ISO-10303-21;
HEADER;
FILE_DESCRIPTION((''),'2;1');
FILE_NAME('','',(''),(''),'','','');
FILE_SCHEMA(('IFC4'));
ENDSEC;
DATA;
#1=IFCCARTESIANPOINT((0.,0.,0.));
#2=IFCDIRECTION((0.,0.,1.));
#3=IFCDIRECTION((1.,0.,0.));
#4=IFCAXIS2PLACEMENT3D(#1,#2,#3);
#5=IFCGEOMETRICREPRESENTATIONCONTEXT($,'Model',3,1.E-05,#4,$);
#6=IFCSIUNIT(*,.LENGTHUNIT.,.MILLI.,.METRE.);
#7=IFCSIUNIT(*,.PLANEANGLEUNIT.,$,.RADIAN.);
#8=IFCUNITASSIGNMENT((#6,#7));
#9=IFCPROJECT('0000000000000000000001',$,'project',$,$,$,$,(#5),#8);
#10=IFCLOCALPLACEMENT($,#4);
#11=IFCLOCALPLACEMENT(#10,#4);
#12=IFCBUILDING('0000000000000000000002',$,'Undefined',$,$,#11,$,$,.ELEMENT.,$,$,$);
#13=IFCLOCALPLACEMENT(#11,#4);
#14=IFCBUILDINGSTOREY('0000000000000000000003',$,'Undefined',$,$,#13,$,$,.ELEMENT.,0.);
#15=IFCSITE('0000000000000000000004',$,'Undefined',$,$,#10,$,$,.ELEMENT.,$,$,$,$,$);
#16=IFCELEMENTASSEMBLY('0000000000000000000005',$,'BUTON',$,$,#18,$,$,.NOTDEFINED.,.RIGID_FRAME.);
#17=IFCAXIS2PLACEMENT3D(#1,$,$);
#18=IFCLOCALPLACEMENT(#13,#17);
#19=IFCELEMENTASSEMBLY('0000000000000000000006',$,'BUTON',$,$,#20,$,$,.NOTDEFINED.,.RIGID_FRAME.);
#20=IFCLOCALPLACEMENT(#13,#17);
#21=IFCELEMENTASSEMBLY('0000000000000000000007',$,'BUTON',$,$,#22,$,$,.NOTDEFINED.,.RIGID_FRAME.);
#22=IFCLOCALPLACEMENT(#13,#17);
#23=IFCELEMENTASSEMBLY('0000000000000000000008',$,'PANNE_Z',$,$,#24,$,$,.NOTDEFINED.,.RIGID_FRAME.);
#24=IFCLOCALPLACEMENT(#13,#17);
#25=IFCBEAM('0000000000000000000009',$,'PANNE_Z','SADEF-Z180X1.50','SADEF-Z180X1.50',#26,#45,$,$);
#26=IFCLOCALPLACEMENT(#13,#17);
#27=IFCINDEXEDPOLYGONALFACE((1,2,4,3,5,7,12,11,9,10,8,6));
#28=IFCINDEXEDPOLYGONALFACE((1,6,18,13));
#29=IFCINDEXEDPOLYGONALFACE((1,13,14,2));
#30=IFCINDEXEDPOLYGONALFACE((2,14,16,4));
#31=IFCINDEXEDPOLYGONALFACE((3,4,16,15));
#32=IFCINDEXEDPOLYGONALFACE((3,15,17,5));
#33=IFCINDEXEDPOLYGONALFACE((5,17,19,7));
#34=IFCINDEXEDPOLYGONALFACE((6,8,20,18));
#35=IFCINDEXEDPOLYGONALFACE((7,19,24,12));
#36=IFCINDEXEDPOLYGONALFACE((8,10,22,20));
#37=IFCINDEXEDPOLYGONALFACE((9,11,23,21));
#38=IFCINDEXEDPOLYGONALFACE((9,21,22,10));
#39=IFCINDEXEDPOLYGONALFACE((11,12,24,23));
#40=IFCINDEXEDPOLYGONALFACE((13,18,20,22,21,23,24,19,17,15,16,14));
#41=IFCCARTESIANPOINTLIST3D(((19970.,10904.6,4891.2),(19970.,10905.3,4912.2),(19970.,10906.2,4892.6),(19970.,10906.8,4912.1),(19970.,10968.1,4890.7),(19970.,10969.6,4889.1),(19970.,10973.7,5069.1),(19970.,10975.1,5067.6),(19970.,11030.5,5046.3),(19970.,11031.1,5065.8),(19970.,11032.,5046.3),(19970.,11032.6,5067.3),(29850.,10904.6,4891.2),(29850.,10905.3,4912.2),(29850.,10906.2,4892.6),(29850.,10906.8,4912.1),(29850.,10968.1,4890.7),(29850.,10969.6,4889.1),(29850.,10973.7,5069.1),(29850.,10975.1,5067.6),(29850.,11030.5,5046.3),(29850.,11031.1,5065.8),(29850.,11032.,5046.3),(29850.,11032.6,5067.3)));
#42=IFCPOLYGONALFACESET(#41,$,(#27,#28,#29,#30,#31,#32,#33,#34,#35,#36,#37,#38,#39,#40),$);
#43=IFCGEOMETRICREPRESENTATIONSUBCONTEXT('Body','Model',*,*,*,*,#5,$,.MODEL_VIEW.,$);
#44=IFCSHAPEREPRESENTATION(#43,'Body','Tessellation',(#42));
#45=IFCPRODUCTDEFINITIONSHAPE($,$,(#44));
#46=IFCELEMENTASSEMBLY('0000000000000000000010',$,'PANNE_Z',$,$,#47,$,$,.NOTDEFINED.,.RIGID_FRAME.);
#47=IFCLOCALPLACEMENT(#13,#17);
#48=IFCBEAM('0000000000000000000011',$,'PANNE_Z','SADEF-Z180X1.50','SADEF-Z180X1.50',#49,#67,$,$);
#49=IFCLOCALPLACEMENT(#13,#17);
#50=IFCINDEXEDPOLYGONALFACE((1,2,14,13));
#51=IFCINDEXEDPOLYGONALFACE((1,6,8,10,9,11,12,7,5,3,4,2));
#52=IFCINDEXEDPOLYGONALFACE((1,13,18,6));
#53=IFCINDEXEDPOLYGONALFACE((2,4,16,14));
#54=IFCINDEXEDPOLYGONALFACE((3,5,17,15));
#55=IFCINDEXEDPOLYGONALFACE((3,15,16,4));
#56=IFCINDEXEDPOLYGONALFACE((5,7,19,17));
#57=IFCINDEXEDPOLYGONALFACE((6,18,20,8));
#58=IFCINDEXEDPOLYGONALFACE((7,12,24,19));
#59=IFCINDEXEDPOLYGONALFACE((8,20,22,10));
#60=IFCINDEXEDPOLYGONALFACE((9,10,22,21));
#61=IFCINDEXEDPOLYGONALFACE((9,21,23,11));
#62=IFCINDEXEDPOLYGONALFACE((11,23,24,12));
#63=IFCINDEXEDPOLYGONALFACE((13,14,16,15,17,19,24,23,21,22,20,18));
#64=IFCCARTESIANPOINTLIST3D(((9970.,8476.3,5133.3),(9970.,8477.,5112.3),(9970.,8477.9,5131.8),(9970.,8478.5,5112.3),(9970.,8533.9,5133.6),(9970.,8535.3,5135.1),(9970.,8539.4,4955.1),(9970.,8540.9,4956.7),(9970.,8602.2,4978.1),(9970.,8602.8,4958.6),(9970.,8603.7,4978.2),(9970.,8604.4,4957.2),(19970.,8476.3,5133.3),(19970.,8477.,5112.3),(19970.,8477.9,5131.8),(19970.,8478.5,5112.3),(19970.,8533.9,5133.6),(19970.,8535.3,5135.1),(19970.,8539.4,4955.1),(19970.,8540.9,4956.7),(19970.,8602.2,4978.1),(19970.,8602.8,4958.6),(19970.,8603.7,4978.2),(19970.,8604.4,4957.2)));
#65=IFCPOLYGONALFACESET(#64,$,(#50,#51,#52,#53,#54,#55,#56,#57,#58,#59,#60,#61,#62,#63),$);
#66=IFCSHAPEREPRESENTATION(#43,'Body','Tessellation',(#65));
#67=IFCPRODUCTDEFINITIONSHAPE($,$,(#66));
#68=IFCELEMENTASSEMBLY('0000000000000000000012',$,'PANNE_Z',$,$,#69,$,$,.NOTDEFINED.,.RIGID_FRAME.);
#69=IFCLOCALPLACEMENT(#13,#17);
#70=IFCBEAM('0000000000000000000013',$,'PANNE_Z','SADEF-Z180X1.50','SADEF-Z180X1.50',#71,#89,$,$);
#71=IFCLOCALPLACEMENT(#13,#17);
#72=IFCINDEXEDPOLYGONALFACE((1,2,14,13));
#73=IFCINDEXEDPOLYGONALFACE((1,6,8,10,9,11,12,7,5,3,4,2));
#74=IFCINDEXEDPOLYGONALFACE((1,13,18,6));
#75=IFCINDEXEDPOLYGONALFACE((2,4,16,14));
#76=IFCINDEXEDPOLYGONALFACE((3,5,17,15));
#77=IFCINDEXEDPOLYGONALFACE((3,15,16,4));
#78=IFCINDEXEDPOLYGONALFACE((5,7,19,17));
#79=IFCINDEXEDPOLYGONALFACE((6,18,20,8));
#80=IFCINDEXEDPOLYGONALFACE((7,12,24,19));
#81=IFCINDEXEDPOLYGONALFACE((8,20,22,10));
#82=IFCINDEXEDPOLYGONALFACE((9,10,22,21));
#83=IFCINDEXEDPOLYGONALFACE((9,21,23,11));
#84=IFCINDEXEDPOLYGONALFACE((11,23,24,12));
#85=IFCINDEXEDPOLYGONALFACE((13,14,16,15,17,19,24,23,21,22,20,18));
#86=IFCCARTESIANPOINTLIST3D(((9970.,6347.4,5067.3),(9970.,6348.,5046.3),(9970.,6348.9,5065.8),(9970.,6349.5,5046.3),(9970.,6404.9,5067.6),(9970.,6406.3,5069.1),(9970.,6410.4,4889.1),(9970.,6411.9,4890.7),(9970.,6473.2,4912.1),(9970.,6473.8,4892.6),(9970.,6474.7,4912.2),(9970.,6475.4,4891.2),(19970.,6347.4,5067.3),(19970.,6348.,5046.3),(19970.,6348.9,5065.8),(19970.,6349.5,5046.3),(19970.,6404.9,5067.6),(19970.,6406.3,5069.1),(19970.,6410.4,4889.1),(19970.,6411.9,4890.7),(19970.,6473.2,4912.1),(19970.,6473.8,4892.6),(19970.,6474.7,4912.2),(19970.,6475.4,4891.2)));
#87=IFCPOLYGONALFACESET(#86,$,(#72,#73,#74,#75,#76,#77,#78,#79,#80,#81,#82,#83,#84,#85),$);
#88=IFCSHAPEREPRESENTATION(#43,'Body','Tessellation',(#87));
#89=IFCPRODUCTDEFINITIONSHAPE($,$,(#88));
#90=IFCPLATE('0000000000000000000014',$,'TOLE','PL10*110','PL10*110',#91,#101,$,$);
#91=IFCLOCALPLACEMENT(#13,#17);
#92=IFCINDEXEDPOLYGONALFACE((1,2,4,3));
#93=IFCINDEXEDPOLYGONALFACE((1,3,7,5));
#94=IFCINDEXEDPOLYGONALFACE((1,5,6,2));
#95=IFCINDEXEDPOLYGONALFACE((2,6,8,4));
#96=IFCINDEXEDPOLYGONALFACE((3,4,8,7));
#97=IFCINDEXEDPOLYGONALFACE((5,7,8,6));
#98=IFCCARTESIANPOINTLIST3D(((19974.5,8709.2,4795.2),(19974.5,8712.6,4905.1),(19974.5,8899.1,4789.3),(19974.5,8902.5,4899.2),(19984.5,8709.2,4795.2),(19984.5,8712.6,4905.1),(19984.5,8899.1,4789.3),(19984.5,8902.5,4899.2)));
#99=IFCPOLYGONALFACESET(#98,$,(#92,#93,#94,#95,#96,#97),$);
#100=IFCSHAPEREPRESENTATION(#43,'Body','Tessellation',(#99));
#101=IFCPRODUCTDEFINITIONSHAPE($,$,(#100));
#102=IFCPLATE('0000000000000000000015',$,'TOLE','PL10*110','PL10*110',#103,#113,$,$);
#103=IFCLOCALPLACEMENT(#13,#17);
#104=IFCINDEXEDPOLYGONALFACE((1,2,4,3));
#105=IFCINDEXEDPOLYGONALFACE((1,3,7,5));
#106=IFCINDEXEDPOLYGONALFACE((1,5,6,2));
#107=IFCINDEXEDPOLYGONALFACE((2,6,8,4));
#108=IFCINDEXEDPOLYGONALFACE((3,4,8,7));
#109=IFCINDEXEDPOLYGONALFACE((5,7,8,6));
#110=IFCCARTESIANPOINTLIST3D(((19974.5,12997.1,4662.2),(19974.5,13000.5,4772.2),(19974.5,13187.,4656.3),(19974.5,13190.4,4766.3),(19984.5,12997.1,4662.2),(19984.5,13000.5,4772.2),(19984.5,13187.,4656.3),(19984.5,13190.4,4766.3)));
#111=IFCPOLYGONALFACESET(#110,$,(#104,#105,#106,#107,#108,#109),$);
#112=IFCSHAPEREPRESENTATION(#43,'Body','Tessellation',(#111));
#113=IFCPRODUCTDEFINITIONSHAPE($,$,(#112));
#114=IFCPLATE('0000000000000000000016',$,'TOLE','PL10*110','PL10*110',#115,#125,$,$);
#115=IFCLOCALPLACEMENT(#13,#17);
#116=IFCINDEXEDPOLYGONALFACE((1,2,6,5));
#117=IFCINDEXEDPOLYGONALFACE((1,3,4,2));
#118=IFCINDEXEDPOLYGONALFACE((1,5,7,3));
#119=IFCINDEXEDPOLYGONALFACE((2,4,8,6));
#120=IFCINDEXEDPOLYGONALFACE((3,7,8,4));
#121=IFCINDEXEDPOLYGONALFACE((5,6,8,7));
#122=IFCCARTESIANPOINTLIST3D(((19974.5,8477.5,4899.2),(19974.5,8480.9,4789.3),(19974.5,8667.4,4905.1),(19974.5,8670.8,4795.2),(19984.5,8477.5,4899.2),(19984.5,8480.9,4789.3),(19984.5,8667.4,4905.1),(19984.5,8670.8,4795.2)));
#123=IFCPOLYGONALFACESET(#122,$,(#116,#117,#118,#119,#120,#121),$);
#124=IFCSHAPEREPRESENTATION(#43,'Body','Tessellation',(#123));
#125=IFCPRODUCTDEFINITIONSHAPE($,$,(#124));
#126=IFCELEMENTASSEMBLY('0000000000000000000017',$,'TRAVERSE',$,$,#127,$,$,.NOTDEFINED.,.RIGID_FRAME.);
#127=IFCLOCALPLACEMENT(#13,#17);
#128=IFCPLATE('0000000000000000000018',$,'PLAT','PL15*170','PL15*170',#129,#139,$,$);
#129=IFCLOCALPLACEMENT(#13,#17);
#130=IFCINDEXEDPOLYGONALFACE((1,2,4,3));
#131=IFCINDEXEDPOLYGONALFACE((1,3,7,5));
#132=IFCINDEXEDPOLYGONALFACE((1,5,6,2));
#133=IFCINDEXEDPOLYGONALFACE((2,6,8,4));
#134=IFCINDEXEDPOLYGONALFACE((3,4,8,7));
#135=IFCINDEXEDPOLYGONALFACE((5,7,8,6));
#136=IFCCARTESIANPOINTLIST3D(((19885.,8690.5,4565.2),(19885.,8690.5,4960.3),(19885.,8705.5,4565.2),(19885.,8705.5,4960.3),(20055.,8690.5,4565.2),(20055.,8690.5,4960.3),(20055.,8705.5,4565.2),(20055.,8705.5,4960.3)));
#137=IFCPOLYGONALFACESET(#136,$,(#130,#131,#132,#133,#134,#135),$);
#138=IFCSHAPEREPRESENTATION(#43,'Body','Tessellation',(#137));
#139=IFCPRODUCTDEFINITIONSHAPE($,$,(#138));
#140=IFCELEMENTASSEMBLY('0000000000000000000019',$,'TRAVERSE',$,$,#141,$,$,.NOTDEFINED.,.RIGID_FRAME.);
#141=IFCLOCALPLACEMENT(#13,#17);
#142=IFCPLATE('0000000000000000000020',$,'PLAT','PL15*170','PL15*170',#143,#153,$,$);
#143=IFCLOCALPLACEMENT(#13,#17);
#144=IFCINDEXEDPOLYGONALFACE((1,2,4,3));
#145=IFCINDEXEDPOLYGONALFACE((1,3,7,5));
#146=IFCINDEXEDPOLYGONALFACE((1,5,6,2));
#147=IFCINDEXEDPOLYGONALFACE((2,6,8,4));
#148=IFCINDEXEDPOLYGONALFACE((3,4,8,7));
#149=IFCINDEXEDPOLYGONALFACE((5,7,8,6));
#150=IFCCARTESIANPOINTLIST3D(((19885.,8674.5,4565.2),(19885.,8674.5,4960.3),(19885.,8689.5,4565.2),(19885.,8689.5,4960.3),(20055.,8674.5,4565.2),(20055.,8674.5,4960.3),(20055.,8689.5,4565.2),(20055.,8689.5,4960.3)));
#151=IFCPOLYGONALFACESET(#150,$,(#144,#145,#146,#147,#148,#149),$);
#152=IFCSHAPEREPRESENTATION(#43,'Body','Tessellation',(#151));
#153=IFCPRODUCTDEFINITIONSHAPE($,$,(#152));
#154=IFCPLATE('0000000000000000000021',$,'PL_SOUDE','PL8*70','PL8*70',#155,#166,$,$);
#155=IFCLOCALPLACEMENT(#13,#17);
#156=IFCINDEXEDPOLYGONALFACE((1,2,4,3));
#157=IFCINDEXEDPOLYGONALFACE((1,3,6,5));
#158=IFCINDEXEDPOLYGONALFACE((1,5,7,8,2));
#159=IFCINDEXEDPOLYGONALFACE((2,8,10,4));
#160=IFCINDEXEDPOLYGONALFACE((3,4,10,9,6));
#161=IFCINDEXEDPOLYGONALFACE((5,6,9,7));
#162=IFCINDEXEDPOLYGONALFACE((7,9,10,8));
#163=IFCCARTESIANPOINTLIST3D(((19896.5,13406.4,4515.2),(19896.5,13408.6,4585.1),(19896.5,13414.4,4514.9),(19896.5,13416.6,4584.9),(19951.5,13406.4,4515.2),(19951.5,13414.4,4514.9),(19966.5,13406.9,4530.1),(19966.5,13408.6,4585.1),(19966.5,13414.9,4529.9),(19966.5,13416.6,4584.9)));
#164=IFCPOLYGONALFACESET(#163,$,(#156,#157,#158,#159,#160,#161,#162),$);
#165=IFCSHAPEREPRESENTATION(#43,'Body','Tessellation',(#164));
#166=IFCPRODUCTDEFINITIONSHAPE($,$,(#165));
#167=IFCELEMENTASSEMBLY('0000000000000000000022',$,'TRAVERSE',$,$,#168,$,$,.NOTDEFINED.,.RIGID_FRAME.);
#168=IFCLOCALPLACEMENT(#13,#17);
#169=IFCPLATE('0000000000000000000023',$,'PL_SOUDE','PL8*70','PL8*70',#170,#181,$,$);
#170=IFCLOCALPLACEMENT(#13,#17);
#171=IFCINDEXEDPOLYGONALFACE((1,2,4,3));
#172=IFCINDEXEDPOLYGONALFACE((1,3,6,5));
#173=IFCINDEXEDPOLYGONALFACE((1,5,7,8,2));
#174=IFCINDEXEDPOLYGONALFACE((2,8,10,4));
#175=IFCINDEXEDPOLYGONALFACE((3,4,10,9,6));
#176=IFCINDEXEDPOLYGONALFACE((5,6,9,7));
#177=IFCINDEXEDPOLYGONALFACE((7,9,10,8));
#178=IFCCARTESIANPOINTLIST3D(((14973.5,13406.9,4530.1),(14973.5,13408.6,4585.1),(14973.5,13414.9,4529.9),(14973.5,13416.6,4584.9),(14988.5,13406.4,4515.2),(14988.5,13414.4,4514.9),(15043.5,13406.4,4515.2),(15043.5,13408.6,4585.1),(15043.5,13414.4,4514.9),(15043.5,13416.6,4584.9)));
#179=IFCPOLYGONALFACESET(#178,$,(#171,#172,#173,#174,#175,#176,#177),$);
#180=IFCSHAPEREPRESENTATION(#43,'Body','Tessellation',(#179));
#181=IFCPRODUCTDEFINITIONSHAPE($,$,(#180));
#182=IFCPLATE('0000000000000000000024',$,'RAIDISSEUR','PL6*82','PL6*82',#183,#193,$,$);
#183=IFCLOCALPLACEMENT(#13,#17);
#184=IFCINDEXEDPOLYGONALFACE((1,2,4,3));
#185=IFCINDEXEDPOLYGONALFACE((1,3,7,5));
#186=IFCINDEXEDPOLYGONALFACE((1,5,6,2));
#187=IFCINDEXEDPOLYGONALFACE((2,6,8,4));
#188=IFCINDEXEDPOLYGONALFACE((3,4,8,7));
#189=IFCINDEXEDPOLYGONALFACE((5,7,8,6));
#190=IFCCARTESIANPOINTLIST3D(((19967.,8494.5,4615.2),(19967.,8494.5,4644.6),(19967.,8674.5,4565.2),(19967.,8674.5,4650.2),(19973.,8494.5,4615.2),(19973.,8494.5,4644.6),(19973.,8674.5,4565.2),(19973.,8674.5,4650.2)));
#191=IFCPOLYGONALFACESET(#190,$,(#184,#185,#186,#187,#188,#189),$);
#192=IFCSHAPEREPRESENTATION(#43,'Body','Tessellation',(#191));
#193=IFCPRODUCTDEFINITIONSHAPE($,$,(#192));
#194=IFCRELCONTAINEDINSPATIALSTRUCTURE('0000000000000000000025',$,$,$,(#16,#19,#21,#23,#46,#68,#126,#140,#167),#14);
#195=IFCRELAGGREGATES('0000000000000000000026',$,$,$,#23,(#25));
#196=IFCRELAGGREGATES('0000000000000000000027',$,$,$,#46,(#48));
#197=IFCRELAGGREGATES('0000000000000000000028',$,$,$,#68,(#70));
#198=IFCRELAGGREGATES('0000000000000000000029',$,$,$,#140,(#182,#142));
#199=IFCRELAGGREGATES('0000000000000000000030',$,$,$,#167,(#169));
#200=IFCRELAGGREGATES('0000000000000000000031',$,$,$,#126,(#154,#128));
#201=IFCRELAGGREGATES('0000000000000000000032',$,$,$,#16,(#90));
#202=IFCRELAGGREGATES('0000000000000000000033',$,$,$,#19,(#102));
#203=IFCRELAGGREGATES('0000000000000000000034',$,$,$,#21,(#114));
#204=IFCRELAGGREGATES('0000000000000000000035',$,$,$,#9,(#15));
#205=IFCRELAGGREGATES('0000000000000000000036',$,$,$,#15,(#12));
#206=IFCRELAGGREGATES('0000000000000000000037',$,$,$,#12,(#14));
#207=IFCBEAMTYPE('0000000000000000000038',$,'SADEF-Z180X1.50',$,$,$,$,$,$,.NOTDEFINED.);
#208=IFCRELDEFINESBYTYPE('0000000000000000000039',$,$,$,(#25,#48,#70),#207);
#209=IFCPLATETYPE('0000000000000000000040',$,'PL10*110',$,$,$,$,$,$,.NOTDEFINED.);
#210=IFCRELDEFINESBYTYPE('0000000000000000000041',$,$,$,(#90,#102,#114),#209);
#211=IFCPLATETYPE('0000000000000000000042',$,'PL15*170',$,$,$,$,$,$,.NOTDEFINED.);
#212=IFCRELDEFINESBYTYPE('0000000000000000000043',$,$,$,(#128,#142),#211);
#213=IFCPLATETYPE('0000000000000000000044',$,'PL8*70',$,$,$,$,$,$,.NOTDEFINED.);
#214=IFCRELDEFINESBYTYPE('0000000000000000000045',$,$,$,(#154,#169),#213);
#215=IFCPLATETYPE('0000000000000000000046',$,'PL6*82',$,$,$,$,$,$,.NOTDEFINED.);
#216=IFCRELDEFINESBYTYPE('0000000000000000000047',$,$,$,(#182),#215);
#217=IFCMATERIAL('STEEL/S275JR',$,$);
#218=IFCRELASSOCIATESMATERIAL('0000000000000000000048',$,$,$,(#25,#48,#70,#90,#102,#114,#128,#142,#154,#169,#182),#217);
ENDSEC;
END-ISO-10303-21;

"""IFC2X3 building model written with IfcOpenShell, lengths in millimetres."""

from ifc_helpers import new_model, si_unit, frame, origin_with_axes, place, context, subcontext, project, spatial, polyline, outline, extrude, material, type_object, element, aggregate, save


model = new_model("IFC2X3")

# Units and contexts
model_context = context("Model", 3, precision=1e-05, world=origin_with_axes())
body_context = subcontext(model_context, "Body", "Model", "MODEL_VIEW")
ifc_project = project(units=[si_unit("LENGTHUNIT", "METRE", prefix="MILLI"), si_unit("PLANEANGLEUNIT", "RADIAN")], contexts=[model_context])

# Site, building, storey
site_placement = place(None, origin_with_axes())
site = spatial("IfcSite", under=ifc_project, at=site_placement, Name="Undefined", CompositionType="ELEMENT")
building_placement = place(site_placement, origin_with_axes())
building = spatial("IfcBuilding", under=site, at=building_placement, Name="Undefined", CompositionType="ELEMENT")
storey_placement = place(building_placement, origin_with_axes())
storey = spatial("IfcBuildingStorey", under=building, at=storey_placement, Name="Undefined", CompositionType="ELEMENT", Elevation=0.0)

# Element assemblies
assembly_1_placement = place(storey_placement, origin_with_axes())
assembly_1 = element("IfcElementAssembly", 1, at=assembly_1_placement, inside=storey, Name="BUTON", AssemblyPlace="NOTDEFINED", PredefinedType="RIGID_FRAME")
ifc_material_1 = material(Name="STEEL/S275JR")
assembly_2_placement = place(storey_placement, origin_with_axes())
assembly_2 = element("IfcElementAssembly", 2, at=assembly_2_placement, inside=storey, Name="BUTON", AssemblyPlace="NOTDEFINED", PredefinedType="RIGID_FRAME")
assembly_3_placement = place(storey_placement, origin_with_axes())
assembly_3 = element("IfcElementAssembly", 3, at=assembly_3_placement, inside=storey, Name="BUTON", AssemblyPlace="NOTDEFINED", PredefinedType="RIGID_FRAME")

# Element assemblies, beams
beam_type_1 = type_object("IfcBeamType", Name="SADEF-Z180X1.50", PredefinedType="NOTDEFINED")
assembly_4_placement = place(storey_placement, origin_with_axes())
assembly_4 = element("IfcElementAssembly", 4, at=assembly_4_placement, inside=storey, Name="PANNE_Z", AssemblyPlace="NOTDEFINED", PredefinedType="RIGID_FRAME")
beam_1_placement = place(assembly_4_placement, frame((19970.0, 10971.6, 4979.1), z_axis=(0.0, 0.031032, 0.999518), x_axis=(1.0, 0.0, 0.0)))
beam_1 = element("IfcBeam", 5, at=beam_1_placement, type_object=beam_type_1, material=ifc_material_1, Name="PANNE_Z", Description="SADEF-Z180X1.50", ObjectType="SADEF-Z180X1.50", context=body_context, shape_type="SweptSolid", body=[
    extrude(outline(polyline([(-56.7, 69.0), (-58.2, 69.0), (-58.2, 90.0), (0.8, 90.0), (0.7, -88.5), (62.7, -88.5), (62.7, -69.0), (64.2, -69.0), (64.2, -90.0), (-0.8, -90.0), (-0.7, 88.5), (-56.7, 88.5), (-56.7, 69.0)])), frame((9880.0, 0.0, 0.0), z_axis=(-1.0, 0.0, 0.0), x_axis=(0.0, -1.0, 0.0)), (0.0, 0.0, 1.0), 9880.0),
])
aggregate(assembly_4, [beam_1])
assembly_5_placement = place(storey_placement, origin_with_axes())
assembly_5 = element("IfcElementAssembly", 6, at=assembly_5_placement, inside=storey, Name="PANNE_Z", AssemblyPlace="NOTDEFINED", PredefinedType="RIGID_FRAME")
beam_2_placement = place(assembly_5_placement, frame((19970.0, 8537.4, 5045.1), z_axis=(0.0, -0.031032, 0.999518), x_axis=(-1.0, 0.0, 0.0)))
beam_2 = element("IfcBeam", 7, at=beam_2_placement, type_object=beam_type_1, material=ifc_material_1, Name="PANNE_Z", Description="SADEF-Z180X1.50", ObjectType="SADEF-Z180X1.50", context=body_context, shape_type="SweptSolid", body=[
    extrude(outline(polyline([(-56.7, 69.0), (-58.2, 69.0), (-58.2, 90.0), (0.8, 90.0), (0.7, -88.5), (62.7, -88.5), (62.7, -69.0), (64.2, -69.0), (64.2, -90.0), (-0.8, -90.0), (-0.7, 88.5), (-56.7, 88.5), (-56.7, 69.0)])), frame((10000.0, 0.0, 0.0), z_axis=(-1.0, 0.0, 0.0), x_axis=(0.0, -1.0, 0.0)), (0.0, 0.0, 1.0), 10000.0),
])
aggregate(assembly_5, [beam_2])
assembly_6_placement = place(storey_placement, origin_with_axes())
assembly_6 = element("IfcElementAssembly", 8, at=assembly_6_placement, inside=storey, Name="PANNE_Z", AssemblyPlace="NOTDEFINED", PredefinedType="RIGID_FRAME")
beam_3_placement = place(assembly_6_placement, frame((19970.0, 6408.4, 4979.1), z_axis=(0.0, -0.031032, 0.999518), x_axis=(-1.0, 0.0, 0.0)))
beam_3 = element("IfcBeam", 9, at=beam_3_placement, type_object=beam_type_1, material=ifc_material_1, Name="PANNE_Z", Description="SADEF-Z180X1.50", ObjectType="SADEF-Z180X1.50", context=body_context, shape_type="SweptSolid", body=[
    extrude(outline(polyline([(-56.7, 69.0), (-58.2, 69.0), (-58.2, 90.0), (0.8, 90.0), (0.7, -88.5), (62.7, -88.5), (62.7, -69.0), (64.2, -69.0), (64.2, -90.0), (-0.8, -90.0), (-0.7, 88.5), (-56.7, 88.5), (-56.7, 69.0)])), frame((10000.0, 0.0, 0.0), z_axis=(-1.0, 0.0, 0.0), x_axis=(0.0, -1.0, 0.0)), (0.0, 0.0, 1.0), 10000.0),
])
aggregate(assembly_6, [beam_3])

# Plates
plate_type_1 = type_object("IfcPlateType", Name="PL10*110", PredefinedType="NOTDEFINED")
plate_1_placement = place(assembly_1_placement, frame((19979.5, 8900.8, 4844.2), z_axis=(1.0, 0.0, 0.0), x_axis=(0.0, -0.99952, 0.030986)))
plate_1 = element("IfcPlate", 10, at=plate_1_placement, type_object=plate_type_1, material=ifc_material_1, Name="TOLE", Description="PL10*110", ObjectType="PL10*110", context=body_context, shape_type="SweptSolid", body=[
    extrude(outline(polyline([(190.0, 55.0), (190.0, -55.0), (0.0, -55.0), (0.0, 55.0), (190.0, 55.0)])), frame((0.0, 0.0, -5.0), z_axis=(0.0, 0.0, 1.0), x_axis=(1.0, 0.0, 0.0)), (0.0, 0.0, 1.0), 10.0),
])
plate_2_placement = place(assembly_2_placement, frame((19979.5, 13188.7, 4711.3), z_axis=(1.0, 0.0, 0.0), x_axis=(0.0, -0.99952, 0.030986)))
plate_2 = element("IfcPlate", 11, at=plate_2_placement, type_object=plate_type_1, material=ifc_material_1, Name="TOLE", Description="PL10*110", ObjectType="PL10*110", context=body_context, shape_type="SweptSolid", body=[
    extrude(outline(polyline([(190.0, 55.0), (190.0, -55.0), (0.0, -55.0), (0.0, 55.0), (190.0, 55.0)])), frame((0.0, 0.0, -5.0), z_axis=(0.0, 0.0, 1.0), x_axis=(1.0, 0.0, 0.0)), (0.0, 0.0, 1.0), 10.0),
])
plate_3_placement = place(assembly_3_placement, frame((19979.5, 8479.2, 4844.2), z_axis=(1.0, 0.0, 0.0), x_axis=(0.0, 0.99952, 0.030986)))
plate_3 = element("IfcPlate", 12, at=plate_3_placement, type_object=plate_type_1, material=ifc_material_1, Name="TOLE", Description="PL10*110", ObjectType="PL10*110", context=body_context, shape_type="SweptSolid", body=[
    extrude(outline(polyline([(0.0, 55.0), (190.0, 55.0), (190.0, -55.0), (0.0, -55.0), (0.0, 55.0)])), frame((0.0, 0.0, -5.0), z_axis=(0.0, 0.0, 1.0), x_axis=(1.0, 0.0, 0.0)), (0.0, 0.0, 1.0), 10.0),
])

# Element assemblies, plates
assembly_7_placement = place(storey_placement, origin_with_axes())
assembly_7 = element("IfcElementAssembly", 13, at=assembly_7_placement, inside=storey, Name="TRAVERSE", AssemblyPlace="NOTDEFINED", PredefinedType="RIGID_FRAME")
plate_type_2 = type_object("IfcPlateType", Name="PL15*170", PredefinedType="NOTDEFINED")
plate_4_placement = place(assembly_7_placement, frame((19970.0, 8698.0, 4565.2), z_axis=(0.0, 1.0, 0.0), x_axis=(0.0, 0.0, 1.0)))
plate_4 = element("IfcPlate", 14, at=plate_4_placement, type_object=plate_type_2, material=ifc_material_1, Name="PLAT", Description="PL15*170", ObjectType="PL15*170", context=body_context, shape_type="SweptSolid", body=[
    extrude(outline(polyline([(0.0, -85.0), (0.0, 85.0), (395.1, 85.0), (395.1, -85.0), (0.0, -85.0)])), frame((0.0, 0.0, -7.5), z_axis=(0.0, 0.0, 1.0), x_axis=(1.0, 0.0, 0.0)), (0.0, 0.0, 1.0), 15.0),
])
assembly_8_placement = place(storey_placement, origin_with_axes())
assembly_8 = element("IfcElementAssembly", 15, at=assembly_8_placement, inside=storey, Name="TRAVERSE", AssemblyPlace="NOTDEFINED", PredefinedType="RIGID_FRAME")
plate_5_placement = place(assembly_8_placement, frame((19970.0, 8682.0, 4565.2), z_axis=(0.0, 1.0, 0.0), x_axis=(0.0, 0.0, 1.0)))
plate_5 = element("IfcPlate", 16, at=plate_5_placement, type_object=plate_type_2, material=ifc_material_1, Name="PLAT", Description="PL15*170", ObjectType="PL15*170", context=body_context, shape_type="SweptSolid", body=[
    extrude(outline(polyline([(0.0, -85.0), (0.0, 85.0), (395.1, 85.0), (395.1, -85.0), (0.0, -85.0)])), frame((0.0, 0.0, -7.5), z_axis=(0.0, 0.0, 1.0), x_axis=(1.0, 0.0, 0.0)), (0.0, 0.0, 1.0), 15.0),
])

# Plate
plate_type_3 = type_object("IfcPlateType", Name="PL8*70", PredefinedType="NOTDEFINED")
plate_6_placement = place(assembly_7_placement, frame((19966.5, 13410.4, 4515.0), z_axis=(0.0, 0.99952, -0.030986), x_axis=(-1.0, 0.0, 0.0)))
plate_6 = element("IfcPlate", 17, at=plate_6_placement, type_object=plate_type_3, material=ifc_material_1, Name="PL_SOUDE", Description="PL8*70", ObjectType="PL8*70", context=body_context, shape_type="SweptSolid", body=[
    extrude(outline(polyline([(0.0, 15.0), (15.0, 0.0), (70.0, 0.0), (70.0, 70.0), (0.0, 70.0), (0.0, 15.0)])), frame((0.0, 0.0, -4.0), z_axis=(0.0, 0.0, 1.0), x_axis=(1.0, 0.0, 0.0)), (0.0, 0.0, 1.0), 8.0),
])

# Element assembly, plate
assembly_9_placement = place(storey_placement, origin_with_axes())
assembly_9 = element("IfcElementAssembly", 18, at=assembly_9_placement, inside=storey, Name="TRAVERSE", AssemblyPlace="NOTDEFINED", PredefinedType="RIGID_FRAME")
plate_7_placement = place(assembly_9_placement, frame((14973.5, 13410.4, 4515.0), z_axis=(0.0, -0.99952, 0.030986), x_axis=(1.0, 0.0, 0.0)))
plate_7 = element("IfcPlate", 19, at=plate_7_placement, type_object=plate_type_3, material=ifc_material_1, Name="PL_SOUDE", Description="PL8*70", ObjectType="PL8*70", context=body_context, shape_type="SweptSolid", body=[
    extrude(outline(polyline([(0.0, 15.0), (15.0, 0.0), (70.0, 0.0), (70.0, 70.0), (0.0, 70.0), (0.0, 15.0)])), frame((0.0, 0.0, -4.0), z_axis=(0.0, 0.0, 1.0), x_axis=(1.0, 0.0, 0.0)), (0.0, 0.0, 1.0), 8.0),
])

# Plate
plate_type_4 = type_object("IfcPlateType", Name="PL6*82", PredefinedType="NOTDEFINED")
plate_8_placement = place(assembly_8_placement, frame((19970.0, 8674.5, 4650.2), z_axis=(-1.0, 0.0, 0.0), x_axis=(0.0, 0.0, -1.0)))
plate_8 = element("IfcPlate", 20, at=plate_8_placement, type_object=plate_type_4, material=ifc_material_1, Name="RAIDISSEUR", Description="PL6*82", ObjectType="PL6*82", context=body_context, shape_type="SweptSolid", body=[
    extrude(outline(polyline([(0.0, 0.0), (85.0, 0.0), (35.0, 180.0), (5.6, 180.0), (0.0, 0.0)])), frame((0.0, 0.0, -3.0), z_axis=(0.0, 0.0, 1.0), x_axis=(1.0, 0.0, 0.0)), (0.0, 0.0, 1.0), 6.0),
])
aggregate(assembly_8, [plate_8, plate_5])

aggregate(assembly_9, [plate_7])
aggregate(assembly_7, [plate_6, plate_4])

aggregate(assembly_1, [plate_1])
aggregate(assembly_2, [plate_2])
aggregate(assembly_3, [plate_3])

save(model, "model.ifc")
